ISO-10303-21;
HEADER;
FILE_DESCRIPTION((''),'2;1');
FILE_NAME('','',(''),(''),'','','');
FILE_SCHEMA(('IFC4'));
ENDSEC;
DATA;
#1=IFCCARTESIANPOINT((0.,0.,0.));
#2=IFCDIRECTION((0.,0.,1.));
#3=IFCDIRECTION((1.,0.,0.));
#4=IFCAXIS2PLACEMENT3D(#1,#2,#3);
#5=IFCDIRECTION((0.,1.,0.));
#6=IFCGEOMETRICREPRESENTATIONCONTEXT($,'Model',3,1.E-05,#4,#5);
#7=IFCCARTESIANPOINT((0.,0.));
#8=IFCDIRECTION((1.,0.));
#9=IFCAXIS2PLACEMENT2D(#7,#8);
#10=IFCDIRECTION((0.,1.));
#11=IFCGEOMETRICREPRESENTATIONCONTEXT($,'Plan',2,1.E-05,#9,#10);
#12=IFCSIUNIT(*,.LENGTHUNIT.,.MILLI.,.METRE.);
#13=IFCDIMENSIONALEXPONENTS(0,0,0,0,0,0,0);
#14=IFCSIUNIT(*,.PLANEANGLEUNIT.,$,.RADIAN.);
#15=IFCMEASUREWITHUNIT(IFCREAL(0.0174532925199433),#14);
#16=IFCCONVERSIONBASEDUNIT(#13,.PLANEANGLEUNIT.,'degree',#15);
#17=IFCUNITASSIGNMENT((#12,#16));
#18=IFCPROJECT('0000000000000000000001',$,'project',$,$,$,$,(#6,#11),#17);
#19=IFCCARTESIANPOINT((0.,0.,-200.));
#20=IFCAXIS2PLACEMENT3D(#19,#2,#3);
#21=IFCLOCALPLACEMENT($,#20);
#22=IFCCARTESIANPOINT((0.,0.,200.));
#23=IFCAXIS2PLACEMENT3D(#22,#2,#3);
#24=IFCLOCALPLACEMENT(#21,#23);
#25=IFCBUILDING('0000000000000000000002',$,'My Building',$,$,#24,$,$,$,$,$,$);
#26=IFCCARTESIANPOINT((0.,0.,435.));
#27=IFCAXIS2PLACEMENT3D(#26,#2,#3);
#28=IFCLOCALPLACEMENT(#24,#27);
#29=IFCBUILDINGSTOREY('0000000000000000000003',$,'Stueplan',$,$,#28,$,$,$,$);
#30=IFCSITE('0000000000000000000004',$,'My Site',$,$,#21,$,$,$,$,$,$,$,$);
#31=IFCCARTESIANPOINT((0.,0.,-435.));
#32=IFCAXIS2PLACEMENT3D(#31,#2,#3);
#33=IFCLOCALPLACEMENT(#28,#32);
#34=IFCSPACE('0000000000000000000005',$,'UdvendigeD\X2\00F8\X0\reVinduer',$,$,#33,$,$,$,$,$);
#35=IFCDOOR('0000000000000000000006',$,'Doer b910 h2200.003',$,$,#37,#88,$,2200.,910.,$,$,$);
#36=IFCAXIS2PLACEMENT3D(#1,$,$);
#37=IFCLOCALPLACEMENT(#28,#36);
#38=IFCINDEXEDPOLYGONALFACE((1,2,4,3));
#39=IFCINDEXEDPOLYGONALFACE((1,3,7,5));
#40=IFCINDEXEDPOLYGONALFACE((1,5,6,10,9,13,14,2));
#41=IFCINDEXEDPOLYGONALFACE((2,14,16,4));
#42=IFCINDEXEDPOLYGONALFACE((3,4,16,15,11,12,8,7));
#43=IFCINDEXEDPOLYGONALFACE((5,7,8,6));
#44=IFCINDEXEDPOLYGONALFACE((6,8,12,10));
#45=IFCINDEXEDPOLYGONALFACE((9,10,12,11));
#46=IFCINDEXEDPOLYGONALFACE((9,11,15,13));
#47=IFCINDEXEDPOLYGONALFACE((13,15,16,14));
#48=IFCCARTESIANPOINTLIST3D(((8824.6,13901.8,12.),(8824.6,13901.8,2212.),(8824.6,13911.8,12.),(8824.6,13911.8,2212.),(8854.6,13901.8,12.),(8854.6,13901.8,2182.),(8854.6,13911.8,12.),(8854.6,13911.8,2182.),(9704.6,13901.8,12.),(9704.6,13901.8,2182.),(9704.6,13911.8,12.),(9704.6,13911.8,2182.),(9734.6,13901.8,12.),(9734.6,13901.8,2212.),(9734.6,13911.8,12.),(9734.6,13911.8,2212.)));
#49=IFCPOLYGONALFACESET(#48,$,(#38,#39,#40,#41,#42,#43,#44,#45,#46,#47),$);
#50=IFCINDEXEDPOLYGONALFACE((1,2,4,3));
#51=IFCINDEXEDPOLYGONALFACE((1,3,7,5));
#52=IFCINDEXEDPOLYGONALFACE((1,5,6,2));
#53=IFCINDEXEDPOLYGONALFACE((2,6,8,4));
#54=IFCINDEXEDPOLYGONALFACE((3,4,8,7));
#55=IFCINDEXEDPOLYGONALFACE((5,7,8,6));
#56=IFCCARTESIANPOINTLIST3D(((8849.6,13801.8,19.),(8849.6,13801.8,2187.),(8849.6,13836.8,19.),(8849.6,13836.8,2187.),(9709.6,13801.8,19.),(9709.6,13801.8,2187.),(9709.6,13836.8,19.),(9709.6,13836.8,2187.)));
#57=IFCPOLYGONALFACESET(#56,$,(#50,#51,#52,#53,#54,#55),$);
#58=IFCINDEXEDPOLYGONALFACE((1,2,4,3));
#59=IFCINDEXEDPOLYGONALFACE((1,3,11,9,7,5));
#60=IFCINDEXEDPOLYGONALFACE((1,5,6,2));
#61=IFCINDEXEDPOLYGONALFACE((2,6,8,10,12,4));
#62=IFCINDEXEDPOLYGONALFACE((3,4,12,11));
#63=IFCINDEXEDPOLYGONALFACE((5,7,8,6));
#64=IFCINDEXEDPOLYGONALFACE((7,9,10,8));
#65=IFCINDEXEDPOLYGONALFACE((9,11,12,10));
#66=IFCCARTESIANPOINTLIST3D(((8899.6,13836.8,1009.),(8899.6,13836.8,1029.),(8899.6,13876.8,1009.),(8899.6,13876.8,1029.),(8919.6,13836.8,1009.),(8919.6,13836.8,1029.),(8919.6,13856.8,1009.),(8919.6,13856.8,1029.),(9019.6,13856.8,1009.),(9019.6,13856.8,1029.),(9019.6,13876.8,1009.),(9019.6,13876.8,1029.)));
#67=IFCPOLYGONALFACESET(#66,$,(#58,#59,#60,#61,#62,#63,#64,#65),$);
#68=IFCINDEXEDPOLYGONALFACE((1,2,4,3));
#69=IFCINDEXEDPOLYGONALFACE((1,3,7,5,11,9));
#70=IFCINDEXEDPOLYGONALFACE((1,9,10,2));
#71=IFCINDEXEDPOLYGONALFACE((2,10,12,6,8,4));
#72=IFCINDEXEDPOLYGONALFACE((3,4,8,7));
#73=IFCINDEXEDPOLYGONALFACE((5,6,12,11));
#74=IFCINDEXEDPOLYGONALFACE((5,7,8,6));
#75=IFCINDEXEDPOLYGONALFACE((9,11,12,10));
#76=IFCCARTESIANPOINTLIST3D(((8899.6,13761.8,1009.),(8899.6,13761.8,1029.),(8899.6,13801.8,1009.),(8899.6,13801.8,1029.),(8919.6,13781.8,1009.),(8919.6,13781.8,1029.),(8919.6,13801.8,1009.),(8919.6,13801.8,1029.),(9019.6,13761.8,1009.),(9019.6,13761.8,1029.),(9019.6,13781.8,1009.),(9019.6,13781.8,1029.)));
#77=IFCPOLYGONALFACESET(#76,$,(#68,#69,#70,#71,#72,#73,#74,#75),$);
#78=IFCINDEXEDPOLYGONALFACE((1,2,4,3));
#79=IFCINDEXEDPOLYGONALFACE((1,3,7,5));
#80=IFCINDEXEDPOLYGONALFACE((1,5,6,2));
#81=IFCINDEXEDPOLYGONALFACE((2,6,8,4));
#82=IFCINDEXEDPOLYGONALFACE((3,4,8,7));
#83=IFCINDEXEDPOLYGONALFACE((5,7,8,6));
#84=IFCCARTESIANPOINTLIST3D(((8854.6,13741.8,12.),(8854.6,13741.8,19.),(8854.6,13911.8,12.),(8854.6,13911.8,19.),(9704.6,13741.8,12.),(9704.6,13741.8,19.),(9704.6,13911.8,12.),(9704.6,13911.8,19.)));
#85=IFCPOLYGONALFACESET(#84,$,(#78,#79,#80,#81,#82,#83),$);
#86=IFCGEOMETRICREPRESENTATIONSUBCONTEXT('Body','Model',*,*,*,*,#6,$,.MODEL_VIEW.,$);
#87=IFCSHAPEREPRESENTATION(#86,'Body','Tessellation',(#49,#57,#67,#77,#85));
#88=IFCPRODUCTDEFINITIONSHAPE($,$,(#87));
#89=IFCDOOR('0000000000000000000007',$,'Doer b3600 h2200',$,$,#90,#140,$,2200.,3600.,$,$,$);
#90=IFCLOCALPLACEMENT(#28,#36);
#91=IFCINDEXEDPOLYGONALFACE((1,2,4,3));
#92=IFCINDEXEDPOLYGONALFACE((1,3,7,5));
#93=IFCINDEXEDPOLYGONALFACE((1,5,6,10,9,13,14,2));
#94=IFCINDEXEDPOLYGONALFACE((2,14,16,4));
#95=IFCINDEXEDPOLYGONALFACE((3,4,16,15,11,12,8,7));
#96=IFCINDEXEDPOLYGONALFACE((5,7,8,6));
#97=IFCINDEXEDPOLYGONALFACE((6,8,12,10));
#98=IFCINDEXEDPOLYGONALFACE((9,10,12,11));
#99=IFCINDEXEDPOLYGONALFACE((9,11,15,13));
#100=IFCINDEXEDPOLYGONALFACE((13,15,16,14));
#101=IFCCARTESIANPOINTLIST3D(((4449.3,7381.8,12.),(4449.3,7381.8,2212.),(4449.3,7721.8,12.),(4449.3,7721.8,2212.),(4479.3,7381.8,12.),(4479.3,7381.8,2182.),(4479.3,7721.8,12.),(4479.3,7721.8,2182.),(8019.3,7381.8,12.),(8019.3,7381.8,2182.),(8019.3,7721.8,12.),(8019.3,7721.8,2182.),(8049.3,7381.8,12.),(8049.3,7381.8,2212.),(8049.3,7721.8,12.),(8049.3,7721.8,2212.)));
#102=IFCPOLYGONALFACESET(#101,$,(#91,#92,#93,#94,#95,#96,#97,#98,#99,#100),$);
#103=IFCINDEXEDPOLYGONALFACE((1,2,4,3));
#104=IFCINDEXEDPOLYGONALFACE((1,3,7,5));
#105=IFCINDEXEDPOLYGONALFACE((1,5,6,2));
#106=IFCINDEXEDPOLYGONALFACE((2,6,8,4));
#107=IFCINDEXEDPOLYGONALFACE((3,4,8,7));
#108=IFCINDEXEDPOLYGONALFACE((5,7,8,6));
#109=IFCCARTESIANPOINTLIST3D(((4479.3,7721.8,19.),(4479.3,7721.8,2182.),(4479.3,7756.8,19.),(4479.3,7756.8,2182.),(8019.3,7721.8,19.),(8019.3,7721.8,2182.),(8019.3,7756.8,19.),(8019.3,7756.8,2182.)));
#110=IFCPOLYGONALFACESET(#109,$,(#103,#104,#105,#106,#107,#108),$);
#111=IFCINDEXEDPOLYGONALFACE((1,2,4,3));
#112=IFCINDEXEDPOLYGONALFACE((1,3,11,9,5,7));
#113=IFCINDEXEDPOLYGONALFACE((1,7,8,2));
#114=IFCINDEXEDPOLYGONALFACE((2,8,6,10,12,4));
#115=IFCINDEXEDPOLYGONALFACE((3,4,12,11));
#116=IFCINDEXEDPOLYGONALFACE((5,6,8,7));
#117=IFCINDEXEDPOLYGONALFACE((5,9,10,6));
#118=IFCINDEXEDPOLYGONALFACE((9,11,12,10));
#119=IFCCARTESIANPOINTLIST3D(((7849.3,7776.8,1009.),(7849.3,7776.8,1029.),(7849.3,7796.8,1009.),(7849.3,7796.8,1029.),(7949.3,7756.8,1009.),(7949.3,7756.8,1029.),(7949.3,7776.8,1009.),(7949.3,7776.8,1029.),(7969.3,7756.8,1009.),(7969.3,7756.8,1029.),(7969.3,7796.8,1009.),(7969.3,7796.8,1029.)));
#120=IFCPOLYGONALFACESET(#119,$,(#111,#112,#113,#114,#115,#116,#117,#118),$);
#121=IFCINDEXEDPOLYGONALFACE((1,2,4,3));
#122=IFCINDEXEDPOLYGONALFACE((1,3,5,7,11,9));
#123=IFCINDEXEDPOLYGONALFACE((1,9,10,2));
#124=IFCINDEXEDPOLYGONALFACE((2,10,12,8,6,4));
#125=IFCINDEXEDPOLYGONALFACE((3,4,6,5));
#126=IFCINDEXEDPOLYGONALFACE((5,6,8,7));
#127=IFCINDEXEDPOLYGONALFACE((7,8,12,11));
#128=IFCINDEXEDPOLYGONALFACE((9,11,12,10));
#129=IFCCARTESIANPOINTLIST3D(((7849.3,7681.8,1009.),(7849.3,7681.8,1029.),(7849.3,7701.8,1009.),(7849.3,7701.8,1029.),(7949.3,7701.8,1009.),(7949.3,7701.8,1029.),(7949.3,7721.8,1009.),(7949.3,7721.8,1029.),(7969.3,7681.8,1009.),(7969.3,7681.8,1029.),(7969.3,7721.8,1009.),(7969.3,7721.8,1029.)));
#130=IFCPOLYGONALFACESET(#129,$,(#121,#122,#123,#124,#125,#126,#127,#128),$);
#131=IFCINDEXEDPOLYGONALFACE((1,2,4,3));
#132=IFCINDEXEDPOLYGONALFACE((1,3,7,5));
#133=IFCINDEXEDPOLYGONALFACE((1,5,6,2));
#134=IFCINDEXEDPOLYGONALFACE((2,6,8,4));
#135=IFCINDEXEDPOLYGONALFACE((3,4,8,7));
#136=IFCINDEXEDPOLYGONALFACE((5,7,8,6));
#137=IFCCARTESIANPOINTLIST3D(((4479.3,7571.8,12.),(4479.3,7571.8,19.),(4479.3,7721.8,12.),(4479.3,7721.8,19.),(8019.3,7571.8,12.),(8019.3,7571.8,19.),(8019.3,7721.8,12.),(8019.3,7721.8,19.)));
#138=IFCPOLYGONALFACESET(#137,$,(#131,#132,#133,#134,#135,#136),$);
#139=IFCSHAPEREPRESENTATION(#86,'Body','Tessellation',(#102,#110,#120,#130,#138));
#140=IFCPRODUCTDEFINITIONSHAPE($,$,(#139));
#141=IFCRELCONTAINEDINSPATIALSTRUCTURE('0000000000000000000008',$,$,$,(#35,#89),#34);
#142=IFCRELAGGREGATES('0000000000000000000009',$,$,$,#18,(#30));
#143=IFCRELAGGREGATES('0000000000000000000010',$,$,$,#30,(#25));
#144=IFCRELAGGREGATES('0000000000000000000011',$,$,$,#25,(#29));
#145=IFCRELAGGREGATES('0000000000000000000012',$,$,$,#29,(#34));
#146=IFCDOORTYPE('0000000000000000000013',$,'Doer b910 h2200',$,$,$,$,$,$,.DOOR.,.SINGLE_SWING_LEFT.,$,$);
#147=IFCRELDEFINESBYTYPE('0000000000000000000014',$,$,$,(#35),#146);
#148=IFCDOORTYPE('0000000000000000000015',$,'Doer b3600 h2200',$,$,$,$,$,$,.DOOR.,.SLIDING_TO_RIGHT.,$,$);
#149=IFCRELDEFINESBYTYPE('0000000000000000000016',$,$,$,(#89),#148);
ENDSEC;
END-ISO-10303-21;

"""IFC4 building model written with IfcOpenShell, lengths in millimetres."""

from ifc_helpers import new_model, entity, si_unit, converted_unit, direction, frame, origin_with_axes, origin_2d_with_axis, place, context, subcontext, project, spatial, line, indexed_curve, outline, extrude, shape, source, transform, mapped, type_object, type_shapes, element, save


model = new_model("IFC4")

# Units and contexts
model_context = context("Model", 3, precision=1e-05, world=origin_with_axes(), true_north=direction((0.0, 1.0, 0.0)))
plan_context = context("Plan", 2, precision=1e-05, world=origin_2d_with_axis(), true_north=direction((0.0, 1.0)))
body_context_1 = subcontext(model_context, "Body", "Model", "MODEL_VIEW")
body_context_2 = subcontext(plan_context, "Body", "Plan", "PLAN_VIEW")
ifc_project = project(units=[si_unit("LENGTHUNIT", "METRE", prefix="MILLI"), converted_unit("PLANEANGLEUNIT", "degree", entity("IfcReal", 0.0174532925199433), si_unit("PLANEANGLEUNIT", "RADIAN"), dimensions=[0, 0, 0, 0, 0, 0, 0])], contexts=[model_context, plan_context])

# Site, building, storey
site_placement = place(None, frame((0.0, 0.0, -200.0), z_axis=(0.0, 0.0, 1.0), x_axis=(1.0, 0.0, 0.0)))
site = spatial("IfcSite", under=ifc_project, at=site_placement, Name="My Site")
building_placement = place(site_placement, frame((0.0, 0.0, 200.0), z_axis=(0.0, 0.0, 1.0), x_axis=(1.0, 0.0, 0.0)))
building = spatial("IfcBuilding", under=site, at=building_placement, Name="My Building")
storey_placement = place(building_placement, frame((0.0, 0.0, 435.0), z_axis=(0.0, 0.0, 1.0), x_axis=(1.0, 0.0, 0.0)))
storey = spatial("IfcBuildingStorey", under=building, at=storey_placement, Name="Stueplan")

# Shared definitions
space_1_placement = place(storey_placement, frame((0.0, 0.0, -435.0), z_axis=(0.0, 0.0, 1.0), x_axis=(1.0, 0.0, 0.0)))
space_1 = spatial("IfcSpace", under=storey, at=space_1_placement, Name="UdvendigeDøreVinduer")

# Doors
door_type_1 = type_object("IfcDoorType", Name="Doer b910 h2200", OperationType="SINGLE_SWING_LEFT", PredefinedType="DOOR")
shared_shape_1 = source(origin_with_axes(), body_context_1, "Body", "SweptSolid", [
    extrude(outline(indexed_curve([(0.0, 0.0), (0.0, 2200.0), (910.0, 2200.0), (910.0, 0.0), (880.0, 0.0), (880.0, 2170.0), (30.0, 2170.0), (30.0, 0.0)], segments=[line(1, 2, 3, 4, 5, 6, 7, 8, 1)])), frame((0.0, 0.0, 0.0), z_axis=(0.0, -1.0, 0.0), x_axis=(1.0, 0.0, 0.0)), (0.0, 0.0, -1.0), 10.0),
    extrude(outline(indexed_curve([(0.0, 0.0), (860.0, 0.0), (860.0, 35.0), (0.0, 35.0)], segments=[line(1, 2, 3, 4, 1)])), frame((25.0, 75.0, 7.0), z_axis=(0.0, 0.0, 1.0), x_axis=(1.0, 0.0, 0.0)), (0.0, 0.0, 1.0), 2168.0),
    extrude(outline(indexed_curve([(0.0, 0.0), (0.0, -40.0), (-120.0, -40.0), (-120.0, -20.0), (-20.0, -20.0), (-20.0, 0.0)], segments=[line(1, 2, 3, 4, 5, 6, 1)])), frame((835.0, 75.0, 997.0), z_axis=(0.0, 0.0, 1.0), x_axis=(1.0, 0.0, 0.0)), (0.0, 0.0, 1.0), 20.0),
    extrude(outline(indexed_curve([(0.0, 0.0), (0.0, 40.0), (-120.0, 40.0), (-120.0, 20.0), (-20.0, 20.0), (-20.0, 0.0)], segments=[line(1, 2, 3, 4, 5, 6, 1)])), frame((835.0, 110.0, 997.0), z_axis=(0.0, 0.0, 1.0), x_axis=(1.0, 0.0, 0.0)), (0.0, 0.0, 1.0), 20.0),
    extrude(outline(indexed_curve([(0.0, 0.0), (850.0, 0.0), (850.0, 170.0), (0.0, 170.0)], segments=[line(1, 2, 3, 4, 1)])), frame((30.0, 0.0, 0.0), z_axis=(0.0, 0.0, 1.0), x_axis=(1.0, 0.0, 0.0)), (0.0, 0.0, 1.0), 7.0),
])
shared_shape_2 = source(origin_with_axes(), body_context_2, "Body", "Curve2D", [
    entity("IfcIndexedPolyCurve", entity("IfcCartesianPointList2D", [[0.0, 0.0], [30.0, 0.0], [30.0, 10.0], [0.0, 10.0]]), [entity("IfcLineIndex", [1, 2, 3, 4, 1])]),
    entity("IfcIndexedPolyCurve", entity("IfcCartesianPointList2D", [[910.0, 0.0], [880.0, 0.0], [880.0, 10.0], [910.0, 10.0]]), [entity("IfcLineIndex", [1, 2, 3, 4, 1])]),
    entity("IfcTrimmedCurve", entity("IfcEllipse", entity("IfcAxis2Placement2D", entity("IfcCartesianPoint", [60.0, 10.0]), entity("IfcDirection", [1.0, 0.0])), 825.0, 860.0), [entity("IfcCartesianPoint", [885.0, 10.0])], [entity("IfcCartesianPoint", [60.0, 870.0])], True, "CARTESIAN"),
    entity("IfcIndexedPolyCurve", entity("IfcCartesianPointList2D", [[25.0, 10.0], [60.0, 10.0], [60.0, 870.0], [25.0, 870.0]]), [entity("IfcLineIndex", [1, 2, 3, 4, 1])]),
])
type_shapes(door_type_1, [shared_shape_1, shared_shape_2])
door_1_placement = place(space_1_placement, frame((9734.6, 13911.8, 447.0), z_axis=(0.0, 0.0, 1.0), x_axis=(-1.0, 0.0, 0.0)))
element("IfcDoor", 1, at=door_1_placement, inside=space_1, type_object=door_type_1, Name="Doer b910 h2200.003", OverallHeight=2200.0, OverallWidth=910.0, shapes=[
    shape(body_context_1, "Body", "MappedRepresentation", [mapped(shared_shape_1, transform((0.0, 0.0, 0.0), x_axis=(1.0, 0.0, 0.0), y_axis=(0.0, 1.0, 0.0), z_axis=(0.0, 0.0, 1.0), scale=1.0))]),
    shape(body_context_2, "Body", "MappedRepresentation", [mapped(shared_shape_2, transform((0.0, 0.0, 0.0), x_axis=(1.0, 0.0, 0.0), y_axis=(0.0, 1.0, 0.0), z_axis=(0.0, 0.0, 1.0), scale=1.0))]),
])
door_type_2 = type_object("IfcDoorType", Name="Doer b3600 h2200", OperationType="SLIDING_TO_RIGHT", PredefinedType="DOOR")
shared_shape_3 = source(origin_with_axes(), body_context_1, "Body", "SweptSolid", [
    extrude(outline(indexed_curve([(0.0, 0.0), (0.0, 2200.0), (3600.0, 2200.0), (3600.0, 0.0), (3570.0, 0.0), (3570.0, 2170.0), (30.0, 2170.0), (30.0, 0.0)], segments=[line(1, 2, 3, 4, 5, 6, 7, 8, 1)])), frame((0.0, 0.0, 0.0), z_axis=(0.0, -1.0, 0.0), x_axis=(1.0, 0.0, 0.0)), (0.0, 0.0, -1.0), 340.0),
    extrude(outline(indexed_curve([(0.0, 0.0), (3540.0, 0.0), (3540.0, 35.0), (0.0, 35.0)], segments=[line(1, 2, 3, 4, 1)])), frame((30.0, -35.0, 7.0), z_axis=(0.0, 0.0, 1.0), x_axis=(1.0, 0.0, 0.0)), (0.0, 0.0, 1.0), 2163.0),
    extrude(outline(indexed_curve([(0.0, 0.0), (0.0, -40.0), (120.0, -40.0), (120.0, -20.0), (20.0, -20.0), (20.0, 0.0)], segments=[line(1, 2, 3, 4, 5, 6, 1)])), frame((80.0, -35.0, 997.0), z_axis=(0.0, 0.0, 1.0), x_axis=(1.0, 0.0, 0.0)), (0.0, 0.0, 1.0), 20.0),
    extrude(outline(indexed_curve([(0.0, 0.0), (0.0, 40.0), (120.0, 40.0), (120.0, 20.0), (20.0, 20.0), (20.0, 0.0)], segments=[line(1, 2, 3, 4, 5, 6, 1)])), frame((80.0, 0.0, 997.0), z_axis=(0.0, 0.0, 1.0), x_axis=(1.0, 0.0, 0.0)), (0.0, 0.0, 1.0), 20.0),
    extrude(outline(indexed_curve([(0.0, 0.0), (3540.0, 0.0), (3540.0, 150.0), (0.0, 150.0)], segments=[line(1, 2, 3, 4, 1)])), frame((30.0, 0.0, 0.0), z_axis=(0.0, 0.0, 1.0), x_axis=(1.0, 0.0, 0.0)), (0.0, 0.0, 1.0), 7.0),
])
shared_shape_4 = source(origin_with_axes(), body_context_2, "Body", "Curve2D", [
    entity("IfcIndexedPolyCurve", entity("IfcCartesianPointList2D", [[0.0, 0.0], [30.0, 0.0], [30.0, 340.0], [0.0, 340.0]]), [entity("IfcLineIndex", [1, 2, 3, 4, 1])]),
    entity("IfcIndexedPolyCurve", entity("IfcCartesianPointList2D", [[3600.0, 0.0], [3570.0, 0.0], [3570.0, 340.0], [3600.0, 340.0]]), [entity("IfcLineIndex", [1, 2, 3, 4, 1])]),
    entity("IfcIndexedPolyCurve", entity("IfcCartesianPointList2D", [[5340.0, -35.0], [1800.0, -35.0], [1800.0, 0.0], [5340.0, 0.0]]), [entity("IfcLineIndex", [1, 2, 3, 4, 1])]),
])
type_shapes(door_type_2, [shared_shape_3, shared_shape_4])
door_2_placement = place(space_1_placement, frame((8049.3, 7721.8, 447.0), z_axis=(0.0, 0.0, 1.0), x_axis=(-1.0, 0.0, 0.0)))
element("IfcDoor", 2, at=door_2_placement, inside=space_1, type_object=door_type_2, Name="Doer b3600 h2200", OverallHeight=2200.0, OverallWidth=3600.0, shapes=[
    shape(body_context_1, "Body", "MappedRepresentation", [mapped(shared_shape_3, transform((0.0, 0.0, 0.0), x_axis=(1.0, 0.0, 0.0), y_axis=(0.0, 1.0, 0.0), z_axis=(0.0, 0.0, 1.0), scale=1.0))]),
    shape(body_context_2, "Body", "MappedRepresentation", [mapped(shared_shape_4, transform((0.0, 0.0, 0.0), x_axis=(1.0, 0.0, 0.0), y_axis=(0.0, 1.0, 0.0), z_axis=(0.0, 0.0, 1.0), scale=1.0))]),
])

save(model, "model.ifc")
